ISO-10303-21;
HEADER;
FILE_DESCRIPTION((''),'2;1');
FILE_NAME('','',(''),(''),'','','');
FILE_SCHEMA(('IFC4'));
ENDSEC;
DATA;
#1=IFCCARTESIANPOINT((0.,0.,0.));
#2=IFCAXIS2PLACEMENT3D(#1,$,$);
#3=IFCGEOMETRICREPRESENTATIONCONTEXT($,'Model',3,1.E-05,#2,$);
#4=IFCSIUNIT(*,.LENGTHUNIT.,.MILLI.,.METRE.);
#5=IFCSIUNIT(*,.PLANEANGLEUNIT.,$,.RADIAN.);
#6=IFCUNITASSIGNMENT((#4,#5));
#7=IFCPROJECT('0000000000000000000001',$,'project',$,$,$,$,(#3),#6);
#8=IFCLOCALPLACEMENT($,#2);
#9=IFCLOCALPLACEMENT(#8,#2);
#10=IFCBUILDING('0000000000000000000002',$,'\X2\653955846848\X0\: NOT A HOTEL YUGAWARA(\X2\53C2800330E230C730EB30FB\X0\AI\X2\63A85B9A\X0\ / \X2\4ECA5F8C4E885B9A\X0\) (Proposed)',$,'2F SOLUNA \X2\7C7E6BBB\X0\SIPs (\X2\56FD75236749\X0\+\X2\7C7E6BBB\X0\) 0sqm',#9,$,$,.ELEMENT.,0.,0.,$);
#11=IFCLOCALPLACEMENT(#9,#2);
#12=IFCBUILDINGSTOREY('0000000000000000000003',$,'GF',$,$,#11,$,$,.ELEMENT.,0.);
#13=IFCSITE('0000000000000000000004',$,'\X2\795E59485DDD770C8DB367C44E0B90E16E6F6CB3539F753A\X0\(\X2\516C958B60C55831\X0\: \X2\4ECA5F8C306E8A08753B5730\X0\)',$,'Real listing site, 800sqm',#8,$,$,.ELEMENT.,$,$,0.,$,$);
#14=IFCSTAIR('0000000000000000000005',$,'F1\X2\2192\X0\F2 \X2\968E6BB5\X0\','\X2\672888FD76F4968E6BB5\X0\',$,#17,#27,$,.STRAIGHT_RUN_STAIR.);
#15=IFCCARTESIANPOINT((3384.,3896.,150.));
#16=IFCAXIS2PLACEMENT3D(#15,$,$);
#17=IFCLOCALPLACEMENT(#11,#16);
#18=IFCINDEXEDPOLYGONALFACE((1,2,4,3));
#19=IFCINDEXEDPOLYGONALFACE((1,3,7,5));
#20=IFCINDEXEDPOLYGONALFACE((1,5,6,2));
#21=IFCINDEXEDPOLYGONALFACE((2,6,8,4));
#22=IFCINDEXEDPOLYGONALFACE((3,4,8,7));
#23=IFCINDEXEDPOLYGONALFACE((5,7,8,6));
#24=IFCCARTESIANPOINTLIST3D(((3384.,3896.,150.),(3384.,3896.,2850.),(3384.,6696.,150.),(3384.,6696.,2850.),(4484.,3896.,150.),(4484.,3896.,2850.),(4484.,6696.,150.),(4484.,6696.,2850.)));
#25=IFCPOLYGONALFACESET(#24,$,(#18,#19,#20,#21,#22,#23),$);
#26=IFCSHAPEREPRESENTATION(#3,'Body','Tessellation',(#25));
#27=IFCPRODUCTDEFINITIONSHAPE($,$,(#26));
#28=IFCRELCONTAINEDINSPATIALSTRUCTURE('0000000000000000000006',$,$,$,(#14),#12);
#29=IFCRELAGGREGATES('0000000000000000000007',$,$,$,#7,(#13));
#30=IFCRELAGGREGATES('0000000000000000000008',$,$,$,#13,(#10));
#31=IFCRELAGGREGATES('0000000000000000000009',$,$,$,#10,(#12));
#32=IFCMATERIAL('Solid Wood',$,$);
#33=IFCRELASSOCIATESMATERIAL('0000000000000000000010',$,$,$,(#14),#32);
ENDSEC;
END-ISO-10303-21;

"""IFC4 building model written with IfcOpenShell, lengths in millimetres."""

from ifc_helpers import new_model, si_unit, frame, frame_2d, origin, place, context, project, spatial, rectangle, extrude, material, element, save


model = new_model("IFC4")

# Units and contexts
model_context = context("Model", 3, precision=1e-05, world=origin())
ifc_project = project(units=[si_unit("LENGTHUNIT", "METRE", prefix="MILLI"), si_unit("PLANEANGLEUNIT", "RADIAN")], contexts=[model_context])

# Site, building, storey
site_placement = place(None, origin())
site = spatial("IfcSite", under=ifc_project, at=site_placement, Name="神奈川県足柄下郡湯河原町(公開情報: 今後の計画地)", ObjectType="Real listing site, 800sqm", CompositionType="ELEMENT", RefElevation=0.0)
building_placement = place(site_placement, origin())
building = spatial("IfcBuilding", under=site, at=building_placement, Name="改善案: NOT A HOTEL YUGAWARA(参考モデル・AI推定 / 今後予定) (Proposed)", ObjectType="2F SOLUNA 籾殻SIPs (国産杉+籾殻) 0sqm", CompositionType="ELEMENT", ElevationOfRefHeight=0.0, ElevationOfTerrain=0.0)
storey_placement = place(building_placement, origin())
storey = spatial("IfcBuildingStorey", under=building, at=storey_placement, Name="GF", CompositionType="ELEMENT", Elevation=0.0)

# Shared definitions
ifc_material_1 = material(Name="Solid Wood")

# Stair
stair_placement = place(storey_placement, frame((3384.0, 3896.0, 150.0)))
element("IfcStair", 1, at=stair_placement, inside=storey, material=ifc_material_1, Name="F1→F2 階段", Description="木製直階段", PredefinedType="STRAIGHT_RUN_STAIR", context=model_context, shape_type="SweptSolid", body=[
    extrude(rectangle(XDim=1100.0, YDim=2800.0, at=frame_2d((550.0, 1400.0))), frame((3384.0, 3896.0, 150.0)), (0.0, 0.0, 1.0), 2700.0),
])

save(model, "model.ifc")
